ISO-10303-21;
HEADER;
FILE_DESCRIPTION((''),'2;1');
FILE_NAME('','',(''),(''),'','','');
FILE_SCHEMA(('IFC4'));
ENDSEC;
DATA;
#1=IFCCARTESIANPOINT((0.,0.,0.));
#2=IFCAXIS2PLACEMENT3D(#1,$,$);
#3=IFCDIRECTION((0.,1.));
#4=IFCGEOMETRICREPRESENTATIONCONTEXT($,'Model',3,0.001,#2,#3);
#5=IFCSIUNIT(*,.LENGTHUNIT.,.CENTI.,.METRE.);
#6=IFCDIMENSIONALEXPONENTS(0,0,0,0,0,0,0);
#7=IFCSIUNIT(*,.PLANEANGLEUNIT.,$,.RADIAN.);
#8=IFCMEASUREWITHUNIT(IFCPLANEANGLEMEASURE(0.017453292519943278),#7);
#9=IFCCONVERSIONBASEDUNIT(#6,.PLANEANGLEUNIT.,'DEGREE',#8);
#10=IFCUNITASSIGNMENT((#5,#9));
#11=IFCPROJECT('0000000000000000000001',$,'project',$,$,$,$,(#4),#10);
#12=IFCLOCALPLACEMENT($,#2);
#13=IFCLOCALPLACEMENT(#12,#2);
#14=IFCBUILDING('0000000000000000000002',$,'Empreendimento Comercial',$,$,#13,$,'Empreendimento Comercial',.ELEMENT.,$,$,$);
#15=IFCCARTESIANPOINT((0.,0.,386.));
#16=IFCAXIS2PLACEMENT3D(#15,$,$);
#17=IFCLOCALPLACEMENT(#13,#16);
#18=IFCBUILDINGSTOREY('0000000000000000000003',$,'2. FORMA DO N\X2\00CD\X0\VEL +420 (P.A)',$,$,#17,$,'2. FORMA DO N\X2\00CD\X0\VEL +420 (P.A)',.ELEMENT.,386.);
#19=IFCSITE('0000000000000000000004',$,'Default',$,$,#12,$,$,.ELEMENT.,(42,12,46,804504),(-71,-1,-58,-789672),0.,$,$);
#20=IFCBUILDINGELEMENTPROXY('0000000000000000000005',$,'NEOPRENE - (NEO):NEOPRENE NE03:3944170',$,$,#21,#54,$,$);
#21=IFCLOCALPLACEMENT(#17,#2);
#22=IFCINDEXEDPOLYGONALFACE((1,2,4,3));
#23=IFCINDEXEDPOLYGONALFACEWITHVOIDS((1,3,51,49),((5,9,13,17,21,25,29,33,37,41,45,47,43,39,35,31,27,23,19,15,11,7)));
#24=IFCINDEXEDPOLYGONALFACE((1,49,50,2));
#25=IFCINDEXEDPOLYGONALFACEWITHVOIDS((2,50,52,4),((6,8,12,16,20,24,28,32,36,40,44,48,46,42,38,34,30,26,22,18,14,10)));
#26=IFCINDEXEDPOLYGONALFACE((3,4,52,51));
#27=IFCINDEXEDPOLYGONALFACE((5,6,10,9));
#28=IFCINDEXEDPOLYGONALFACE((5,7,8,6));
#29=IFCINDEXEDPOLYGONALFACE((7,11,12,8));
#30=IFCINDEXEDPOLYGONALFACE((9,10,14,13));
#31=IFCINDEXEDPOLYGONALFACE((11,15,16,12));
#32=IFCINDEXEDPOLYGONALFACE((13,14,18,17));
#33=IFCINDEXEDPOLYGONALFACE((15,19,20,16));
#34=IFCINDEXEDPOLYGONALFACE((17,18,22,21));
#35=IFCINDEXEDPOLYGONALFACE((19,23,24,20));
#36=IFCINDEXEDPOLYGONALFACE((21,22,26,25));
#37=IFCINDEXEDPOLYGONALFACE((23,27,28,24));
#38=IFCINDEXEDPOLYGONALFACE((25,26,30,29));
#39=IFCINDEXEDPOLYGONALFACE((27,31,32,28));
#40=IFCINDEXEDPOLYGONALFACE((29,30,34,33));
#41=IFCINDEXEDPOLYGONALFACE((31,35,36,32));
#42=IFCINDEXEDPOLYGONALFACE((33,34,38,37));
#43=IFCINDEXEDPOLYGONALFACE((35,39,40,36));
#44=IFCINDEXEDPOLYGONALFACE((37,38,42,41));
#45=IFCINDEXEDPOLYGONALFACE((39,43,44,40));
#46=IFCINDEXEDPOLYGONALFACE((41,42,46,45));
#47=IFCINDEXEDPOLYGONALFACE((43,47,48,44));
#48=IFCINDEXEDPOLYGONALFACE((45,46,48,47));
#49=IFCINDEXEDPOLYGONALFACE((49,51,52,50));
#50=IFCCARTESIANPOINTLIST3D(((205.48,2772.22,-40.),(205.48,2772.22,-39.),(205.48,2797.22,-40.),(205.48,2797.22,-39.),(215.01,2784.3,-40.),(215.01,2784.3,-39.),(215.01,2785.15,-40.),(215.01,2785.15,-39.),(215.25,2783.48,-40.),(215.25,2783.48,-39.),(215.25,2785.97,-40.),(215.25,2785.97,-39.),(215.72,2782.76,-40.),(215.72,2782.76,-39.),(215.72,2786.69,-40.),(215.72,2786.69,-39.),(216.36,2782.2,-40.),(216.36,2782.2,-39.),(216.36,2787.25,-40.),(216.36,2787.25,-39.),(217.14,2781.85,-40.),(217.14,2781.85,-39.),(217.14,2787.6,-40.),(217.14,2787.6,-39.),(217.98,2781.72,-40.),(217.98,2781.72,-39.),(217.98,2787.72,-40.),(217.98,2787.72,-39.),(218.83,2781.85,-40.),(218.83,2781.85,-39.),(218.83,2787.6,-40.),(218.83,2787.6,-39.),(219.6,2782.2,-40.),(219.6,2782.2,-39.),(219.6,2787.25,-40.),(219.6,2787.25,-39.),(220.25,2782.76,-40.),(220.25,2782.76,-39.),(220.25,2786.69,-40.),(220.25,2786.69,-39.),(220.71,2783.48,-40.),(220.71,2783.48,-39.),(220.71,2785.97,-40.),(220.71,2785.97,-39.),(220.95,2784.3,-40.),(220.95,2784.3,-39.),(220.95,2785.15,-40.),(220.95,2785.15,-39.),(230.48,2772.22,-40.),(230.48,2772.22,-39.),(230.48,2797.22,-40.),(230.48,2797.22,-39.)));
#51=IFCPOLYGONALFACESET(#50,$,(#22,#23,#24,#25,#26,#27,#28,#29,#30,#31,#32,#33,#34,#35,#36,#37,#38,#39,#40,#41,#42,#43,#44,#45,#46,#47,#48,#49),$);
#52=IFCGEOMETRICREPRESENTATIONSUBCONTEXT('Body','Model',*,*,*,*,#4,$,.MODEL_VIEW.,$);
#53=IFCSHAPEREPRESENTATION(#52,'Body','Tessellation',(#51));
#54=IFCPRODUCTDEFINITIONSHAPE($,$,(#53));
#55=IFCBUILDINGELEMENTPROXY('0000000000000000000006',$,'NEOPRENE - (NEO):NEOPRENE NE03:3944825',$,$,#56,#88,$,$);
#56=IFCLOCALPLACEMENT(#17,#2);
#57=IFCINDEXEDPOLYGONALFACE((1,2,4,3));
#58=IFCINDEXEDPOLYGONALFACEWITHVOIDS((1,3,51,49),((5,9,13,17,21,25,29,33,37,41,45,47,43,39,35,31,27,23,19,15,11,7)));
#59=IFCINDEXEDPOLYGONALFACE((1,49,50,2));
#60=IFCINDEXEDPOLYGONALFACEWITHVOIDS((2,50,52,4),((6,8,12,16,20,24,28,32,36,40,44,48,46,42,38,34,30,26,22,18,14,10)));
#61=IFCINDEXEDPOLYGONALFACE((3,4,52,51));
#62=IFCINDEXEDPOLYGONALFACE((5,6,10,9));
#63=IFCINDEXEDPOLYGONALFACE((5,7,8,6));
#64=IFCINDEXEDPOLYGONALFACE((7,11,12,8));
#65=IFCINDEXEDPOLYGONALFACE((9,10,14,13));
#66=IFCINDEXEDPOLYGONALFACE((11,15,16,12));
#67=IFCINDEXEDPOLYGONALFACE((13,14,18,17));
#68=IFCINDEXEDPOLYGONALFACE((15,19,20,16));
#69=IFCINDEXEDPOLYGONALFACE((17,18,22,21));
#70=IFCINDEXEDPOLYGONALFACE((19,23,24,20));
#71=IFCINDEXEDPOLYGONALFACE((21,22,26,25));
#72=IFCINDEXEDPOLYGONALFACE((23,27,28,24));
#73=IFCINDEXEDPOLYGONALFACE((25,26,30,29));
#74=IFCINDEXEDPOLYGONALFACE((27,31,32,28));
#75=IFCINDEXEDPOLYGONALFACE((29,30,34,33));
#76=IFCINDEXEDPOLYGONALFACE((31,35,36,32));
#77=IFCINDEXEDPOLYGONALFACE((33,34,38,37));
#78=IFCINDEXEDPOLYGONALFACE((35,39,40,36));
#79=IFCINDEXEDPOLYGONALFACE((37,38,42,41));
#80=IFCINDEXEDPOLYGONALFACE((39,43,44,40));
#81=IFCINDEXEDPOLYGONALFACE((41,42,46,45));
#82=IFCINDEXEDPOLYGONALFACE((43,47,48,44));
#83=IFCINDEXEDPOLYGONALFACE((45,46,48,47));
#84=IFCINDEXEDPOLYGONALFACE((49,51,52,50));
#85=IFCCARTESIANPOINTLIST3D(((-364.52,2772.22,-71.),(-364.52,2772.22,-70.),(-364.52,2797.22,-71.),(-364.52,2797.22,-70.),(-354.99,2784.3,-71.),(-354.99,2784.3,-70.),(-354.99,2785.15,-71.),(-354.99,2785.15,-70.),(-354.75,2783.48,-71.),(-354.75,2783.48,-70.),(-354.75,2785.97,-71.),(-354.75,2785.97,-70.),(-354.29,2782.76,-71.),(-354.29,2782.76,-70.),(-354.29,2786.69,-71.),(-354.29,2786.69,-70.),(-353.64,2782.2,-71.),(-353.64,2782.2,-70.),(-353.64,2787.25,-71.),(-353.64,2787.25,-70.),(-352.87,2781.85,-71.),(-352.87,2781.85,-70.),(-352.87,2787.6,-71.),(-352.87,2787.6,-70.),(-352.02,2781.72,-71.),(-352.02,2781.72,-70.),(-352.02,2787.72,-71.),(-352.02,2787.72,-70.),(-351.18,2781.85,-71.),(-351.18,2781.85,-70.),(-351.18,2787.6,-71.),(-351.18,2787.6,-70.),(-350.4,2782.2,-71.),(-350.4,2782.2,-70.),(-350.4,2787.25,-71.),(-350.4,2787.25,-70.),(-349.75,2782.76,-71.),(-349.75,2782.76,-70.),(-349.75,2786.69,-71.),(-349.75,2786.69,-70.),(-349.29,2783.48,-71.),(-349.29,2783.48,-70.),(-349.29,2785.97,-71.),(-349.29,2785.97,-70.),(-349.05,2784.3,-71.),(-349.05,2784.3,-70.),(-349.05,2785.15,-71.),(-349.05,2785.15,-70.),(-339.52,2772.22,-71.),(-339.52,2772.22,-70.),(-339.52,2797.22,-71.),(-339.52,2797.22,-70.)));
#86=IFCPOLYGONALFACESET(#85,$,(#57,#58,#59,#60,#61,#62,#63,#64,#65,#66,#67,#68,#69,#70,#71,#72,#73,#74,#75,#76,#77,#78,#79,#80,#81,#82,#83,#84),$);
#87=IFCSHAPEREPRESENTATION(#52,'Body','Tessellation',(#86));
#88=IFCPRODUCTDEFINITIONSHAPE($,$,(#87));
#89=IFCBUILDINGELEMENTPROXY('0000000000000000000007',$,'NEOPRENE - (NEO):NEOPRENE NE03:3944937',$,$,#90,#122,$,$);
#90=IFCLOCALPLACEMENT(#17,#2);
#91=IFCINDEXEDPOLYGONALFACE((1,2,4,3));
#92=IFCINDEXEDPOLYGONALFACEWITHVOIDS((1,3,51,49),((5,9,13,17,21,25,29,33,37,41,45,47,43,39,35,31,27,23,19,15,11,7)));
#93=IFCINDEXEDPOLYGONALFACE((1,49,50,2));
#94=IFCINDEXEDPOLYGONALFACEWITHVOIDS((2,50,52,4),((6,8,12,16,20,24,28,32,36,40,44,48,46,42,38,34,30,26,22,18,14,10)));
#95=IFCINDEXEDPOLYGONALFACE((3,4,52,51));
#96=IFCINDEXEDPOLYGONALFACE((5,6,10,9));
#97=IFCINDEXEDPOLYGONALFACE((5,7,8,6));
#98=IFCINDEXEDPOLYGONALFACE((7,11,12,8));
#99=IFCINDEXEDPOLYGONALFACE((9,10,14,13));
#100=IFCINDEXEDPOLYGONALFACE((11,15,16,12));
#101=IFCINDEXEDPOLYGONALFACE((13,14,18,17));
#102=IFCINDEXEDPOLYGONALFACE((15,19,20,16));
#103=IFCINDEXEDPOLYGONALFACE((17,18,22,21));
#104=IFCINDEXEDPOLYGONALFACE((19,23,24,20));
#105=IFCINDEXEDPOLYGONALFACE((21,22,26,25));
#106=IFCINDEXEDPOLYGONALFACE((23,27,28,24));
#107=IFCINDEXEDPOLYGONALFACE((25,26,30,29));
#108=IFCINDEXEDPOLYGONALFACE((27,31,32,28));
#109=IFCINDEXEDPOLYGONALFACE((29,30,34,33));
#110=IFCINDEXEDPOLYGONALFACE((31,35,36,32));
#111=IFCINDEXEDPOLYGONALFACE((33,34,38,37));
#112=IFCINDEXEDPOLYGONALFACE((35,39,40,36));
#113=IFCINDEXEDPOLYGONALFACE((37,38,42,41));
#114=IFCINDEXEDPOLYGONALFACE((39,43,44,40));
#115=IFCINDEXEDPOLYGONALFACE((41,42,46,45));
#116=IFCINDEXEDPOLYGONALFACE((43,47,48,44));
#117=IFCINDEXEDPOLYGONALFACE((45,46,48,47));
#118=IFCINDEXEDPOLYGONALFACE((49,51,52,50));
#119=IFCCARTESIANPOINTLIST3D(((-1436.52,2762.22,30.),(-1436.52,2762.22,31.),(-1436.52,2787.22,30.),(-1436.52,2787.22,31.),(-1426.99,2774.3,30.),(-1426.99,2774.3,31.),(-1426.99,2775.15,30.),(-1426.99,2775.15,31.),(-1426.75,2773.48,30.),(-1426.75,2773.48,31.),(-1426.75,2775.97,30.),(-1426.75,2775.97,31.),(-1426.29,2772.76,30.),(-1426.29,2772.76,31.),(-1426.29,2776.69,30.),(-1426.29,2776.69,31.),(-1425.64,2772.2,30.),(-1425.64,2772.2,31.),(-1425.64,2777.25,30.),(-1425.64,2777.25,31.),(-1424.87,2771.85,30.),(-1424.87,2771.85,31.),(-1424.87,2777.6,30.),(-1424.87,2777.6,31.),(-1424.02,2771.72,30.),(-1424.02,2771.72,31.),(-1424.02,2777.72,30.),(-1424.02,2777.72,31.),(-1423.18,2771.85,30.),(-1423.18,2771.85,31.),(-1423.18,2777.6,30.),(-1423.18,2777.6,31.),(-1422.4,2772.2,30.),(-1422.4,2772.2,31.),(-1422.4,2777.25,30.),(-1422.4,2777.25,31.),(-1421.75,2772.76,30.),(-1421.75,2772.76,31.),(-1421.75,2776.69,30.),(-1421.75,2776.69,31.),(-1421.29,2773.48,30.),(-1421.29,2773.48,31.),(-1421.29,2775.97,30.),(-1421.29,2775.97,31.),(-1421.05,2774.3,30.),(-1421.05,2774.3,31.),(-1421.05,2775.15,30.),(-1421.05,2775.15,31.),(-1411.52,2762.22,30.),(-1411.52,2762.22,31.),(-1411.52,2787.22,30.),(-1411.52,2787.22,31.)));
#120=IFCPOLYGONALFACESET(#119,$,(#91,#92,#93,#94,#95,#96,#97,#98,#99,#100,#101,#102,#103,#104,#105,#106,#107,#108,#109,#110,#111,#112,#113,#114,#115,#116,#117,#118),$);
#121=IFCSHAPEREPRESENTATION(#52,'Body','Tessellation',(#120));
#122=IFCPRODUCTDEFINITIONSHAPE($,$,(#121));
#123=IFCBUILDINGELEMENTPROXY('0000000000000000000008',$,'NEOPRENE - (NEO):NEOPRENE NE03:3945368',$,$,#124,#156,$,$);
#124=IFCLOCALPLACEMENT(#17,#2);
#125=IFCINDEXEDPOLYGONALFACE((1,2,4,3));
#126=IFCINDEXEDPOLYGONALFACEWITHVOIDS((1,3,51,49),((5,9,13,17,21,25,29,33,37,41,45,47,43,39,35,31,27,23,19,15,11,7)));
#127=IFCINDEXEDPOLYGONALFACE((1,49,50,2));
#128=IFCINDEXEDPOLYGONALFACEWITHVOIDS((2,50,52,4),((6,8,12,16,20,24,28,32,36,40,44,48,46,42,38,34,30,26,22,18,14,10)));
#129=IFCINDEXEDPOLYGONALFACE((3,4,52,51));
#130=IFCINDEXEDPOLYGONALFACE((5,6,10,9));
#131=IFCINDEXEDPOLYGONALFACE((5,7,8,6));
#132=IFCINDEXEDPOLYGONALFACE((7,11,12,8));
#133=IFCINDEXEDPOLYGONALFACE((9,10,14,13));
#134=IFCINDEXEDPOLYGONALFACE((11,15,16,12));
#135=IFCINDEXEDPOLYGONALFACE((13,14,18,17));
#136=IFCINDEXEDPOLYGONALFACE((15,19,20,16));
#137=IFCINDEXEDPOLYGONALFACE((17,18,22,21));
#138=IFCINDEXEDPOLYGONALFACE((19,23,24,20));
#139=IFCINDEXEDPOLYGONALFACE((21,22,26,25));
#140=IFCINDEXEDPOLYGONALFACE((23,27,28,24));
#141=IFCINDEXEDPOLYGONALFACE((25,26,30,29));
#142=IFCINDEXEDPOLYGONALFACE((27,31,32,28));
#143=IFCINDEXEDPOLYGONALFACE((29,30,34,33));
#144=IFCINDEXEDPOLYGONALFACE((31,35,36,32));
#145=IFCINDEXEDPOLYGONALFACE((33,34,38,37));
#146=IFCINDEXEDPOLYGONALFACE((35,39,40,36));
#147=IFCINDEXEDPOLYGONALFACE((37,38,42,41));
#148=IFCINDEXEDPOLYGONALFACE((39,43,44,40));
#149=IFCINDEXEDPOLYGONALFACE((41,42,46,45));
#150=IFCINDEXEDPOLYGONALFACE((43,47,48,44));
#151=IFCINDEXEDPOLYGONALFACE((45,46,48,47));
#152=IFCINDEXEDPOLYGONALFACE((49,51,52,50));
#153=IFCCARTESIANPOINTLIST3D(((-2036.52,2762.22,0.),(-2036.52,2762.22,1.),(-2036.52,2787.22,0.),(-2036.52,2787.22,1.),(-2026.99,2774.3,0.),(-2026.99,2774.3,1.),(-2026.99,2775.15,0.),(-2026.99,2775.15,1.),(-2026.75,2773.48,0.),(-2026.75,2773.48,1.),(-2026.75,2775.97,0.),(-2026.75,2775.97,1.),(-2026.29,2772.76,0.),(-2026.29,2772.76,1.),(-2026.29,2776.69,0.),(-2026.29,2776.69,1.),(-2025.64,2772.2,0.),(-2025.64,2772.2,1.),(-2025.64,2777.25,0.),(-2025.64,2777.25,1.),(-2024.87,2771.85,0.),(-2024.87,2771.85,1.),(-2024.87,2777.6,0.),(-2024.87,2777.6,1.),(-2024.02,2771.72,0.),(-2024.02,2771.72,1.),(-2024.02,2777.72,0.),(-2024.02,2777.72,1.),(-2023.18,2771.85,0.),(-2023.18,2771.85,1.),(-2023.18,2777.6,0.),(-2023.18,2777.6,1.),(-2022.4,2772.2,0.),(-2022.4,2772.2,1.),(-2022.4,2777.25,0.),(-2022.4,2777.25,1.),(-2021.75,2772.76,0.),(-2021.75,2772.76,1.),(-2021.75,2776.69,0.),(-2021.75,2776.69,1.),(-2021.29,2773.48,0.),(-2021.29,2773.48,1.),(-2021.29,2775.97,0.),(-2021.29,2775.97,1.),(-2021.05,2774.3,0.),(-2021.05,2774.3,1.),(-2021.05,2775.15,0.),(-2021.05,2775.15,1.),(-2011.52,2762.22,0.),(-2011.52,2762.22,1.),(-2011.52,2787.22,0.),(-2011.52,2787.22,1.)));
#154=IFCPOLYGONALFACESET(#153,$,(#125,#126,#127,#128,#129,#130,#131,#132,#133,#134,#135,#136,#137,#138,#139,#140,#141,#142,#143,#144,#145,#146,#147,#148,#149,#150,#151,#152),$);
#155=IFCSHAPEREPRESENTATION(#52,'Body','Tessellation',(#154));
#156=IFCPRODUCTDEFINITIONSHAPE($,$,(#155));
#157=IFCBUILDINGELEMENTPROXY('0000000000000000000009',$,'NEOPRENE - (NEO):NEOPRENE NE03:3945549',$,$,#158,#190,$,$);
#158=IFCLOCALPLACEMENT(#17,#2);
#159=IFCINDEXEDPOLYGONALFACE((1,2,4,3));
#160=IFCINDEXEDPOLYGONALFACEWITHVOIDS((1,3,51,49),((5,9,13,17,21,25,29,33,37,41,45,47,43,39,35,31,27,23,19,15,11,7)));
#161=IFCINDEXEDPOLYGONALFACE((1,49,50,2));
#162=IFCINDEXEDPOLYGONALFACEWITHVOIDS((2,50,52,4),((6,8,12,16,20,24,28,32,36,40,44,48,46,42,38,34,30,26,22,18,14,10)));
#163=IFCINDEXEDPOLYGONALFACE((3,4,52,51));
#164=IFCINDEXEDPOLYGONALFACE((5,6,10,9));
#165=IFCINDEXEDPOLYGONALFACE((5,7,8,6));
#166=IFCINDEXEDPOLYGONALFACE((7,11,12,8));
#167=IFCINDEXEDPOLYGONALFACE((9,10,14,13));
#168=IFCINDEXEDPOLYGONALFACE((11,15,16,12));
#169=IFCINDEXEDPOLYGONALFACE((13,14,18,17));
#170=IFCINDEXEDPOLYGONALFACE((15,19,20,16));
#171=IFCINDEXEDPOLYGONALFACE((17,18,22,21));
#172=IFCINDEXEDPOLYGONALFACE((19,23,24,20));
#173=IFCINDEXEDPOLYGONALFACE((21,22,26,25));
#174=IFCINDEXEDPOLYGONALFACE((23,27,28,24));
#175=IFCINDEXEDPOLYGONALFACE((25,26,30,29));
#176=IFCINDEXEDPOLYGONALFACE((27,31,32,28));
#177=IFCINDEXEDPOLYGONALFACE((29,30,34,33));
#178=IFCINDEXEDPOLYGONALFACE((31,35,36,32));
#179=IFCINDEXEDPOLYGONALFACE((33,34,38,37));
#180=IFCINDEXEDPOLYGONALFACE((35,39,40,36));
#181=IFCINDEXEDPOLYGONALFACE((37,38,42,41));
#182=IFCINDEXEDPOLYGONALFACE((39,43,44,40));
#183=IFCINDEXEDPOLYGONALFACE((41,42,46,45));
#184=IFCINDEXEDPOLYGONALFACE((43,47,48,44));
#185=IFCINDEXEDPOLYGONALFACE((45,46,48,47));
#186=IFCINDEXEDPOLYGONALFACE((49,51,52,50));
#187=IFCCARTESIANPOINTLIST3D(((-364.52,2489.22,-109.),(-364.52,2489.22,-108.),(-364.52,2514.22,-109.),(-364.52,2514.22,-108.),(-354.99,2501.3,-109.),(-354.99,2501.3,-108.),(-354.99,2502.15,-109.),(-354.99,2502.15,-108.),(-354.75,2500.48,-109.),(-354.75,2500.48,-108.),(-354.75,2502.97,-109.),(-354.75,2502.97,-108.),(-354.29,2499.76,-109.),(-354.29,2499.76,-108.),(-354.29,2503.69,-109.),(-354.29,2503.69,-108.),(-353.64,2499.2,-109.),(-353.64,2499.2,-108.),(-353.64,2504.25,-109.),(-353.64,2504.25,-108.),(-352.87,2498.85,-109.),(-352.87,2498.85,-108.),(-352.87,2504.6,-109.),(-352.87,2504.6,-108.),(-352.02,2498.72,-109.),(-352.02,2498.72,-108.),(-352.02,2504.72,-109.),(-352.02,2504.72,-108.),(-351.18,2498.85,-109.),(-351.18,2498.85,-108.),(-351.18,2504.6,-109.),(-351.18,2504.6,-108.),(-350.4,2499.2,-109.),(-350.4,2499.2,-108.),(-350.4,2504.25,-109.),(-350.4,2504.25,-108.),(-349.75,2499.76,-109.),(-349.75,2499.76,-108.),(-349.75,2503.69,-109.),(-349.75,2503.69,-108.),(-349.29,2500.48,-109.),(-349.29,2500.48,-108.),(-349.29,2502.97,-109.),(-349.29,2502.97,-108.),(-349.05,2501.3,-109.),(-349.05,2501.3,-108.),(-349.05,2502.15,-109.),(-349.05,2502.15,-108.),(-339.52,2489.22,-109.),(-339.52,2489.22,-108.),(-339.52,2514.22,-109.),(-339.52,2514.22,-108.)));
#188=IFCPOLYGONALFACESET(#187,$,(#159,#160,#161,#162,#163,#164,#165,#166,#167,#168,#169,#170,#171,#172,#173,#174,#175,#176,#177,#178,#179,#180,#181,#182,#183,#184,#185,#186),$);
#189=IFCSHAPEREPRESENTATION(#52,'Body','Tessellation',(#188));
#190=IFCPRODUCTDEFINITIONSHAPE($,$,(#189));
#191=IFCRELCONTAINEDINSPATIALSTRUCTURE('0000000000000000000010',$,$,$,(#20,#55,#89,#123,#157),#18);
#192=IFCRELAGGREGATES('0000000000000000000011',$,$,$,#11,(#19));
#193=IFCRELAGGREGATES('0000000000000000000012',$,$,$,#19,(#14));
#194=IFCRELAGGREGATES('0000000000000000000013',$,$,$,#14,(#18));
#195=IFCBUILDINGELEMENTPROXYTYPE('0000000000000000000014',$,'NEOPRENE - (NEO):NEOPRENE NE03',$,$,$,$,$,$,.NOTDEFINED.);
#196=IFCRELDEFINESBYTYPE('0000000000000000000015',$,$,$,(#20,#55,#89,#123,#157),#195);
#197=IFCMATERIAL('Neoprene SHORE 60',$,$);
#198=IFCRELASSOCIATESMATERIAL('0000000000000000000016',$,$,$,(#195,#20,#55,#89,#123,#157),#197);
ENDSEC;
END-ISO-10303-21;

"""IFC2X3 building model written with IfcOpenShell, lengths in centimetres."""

from ifc_helpers import new_model, entity, si_unit, converted_unit, direction, frame, frame_2d, origin, place, context, subcontext, project, spatial, polyline, circle_curve, parameter, trimmed, segment, composite_curve, outline, extrude, source, transform, mapped, material, type_object, type_shapes, element, save


model = new_model("IFC2X3")

# Units and contexts
model_context = context("Model", 3, precision=0.001, world=origin(), true_north=direction((0.0, 1.0)))
body_context = subcontext(model_context, "Body", "Model", "MODEL_VIEW")
ifc_project = project(units=[si_unit("LENGTHUNIT", "METRE", prefix="CENTI"), converted_unit("PLANEANGLEUNIT", "DEGREE", entity("IfcPlaneAngleMeasure", 0.017453292519943278), si_unit("PLANEANGLEUNIT", "RADIAN"), dimensions=[0, 0, 0, 0, 0, 0, 0])], contexts=[model_context])

# Site, building, storey
site_placement = place(None, origin())
site = spatial("IfcSite", under=ifc_project, at=site_placement, Name="Default", CompositionType="ELEMENT", RefLatitude=(42, 12, 46, 804504), RefLongitude=(-71, -1, -58, -789672), RefElevation=0.0)
building_placement = place(site_placement, origin())
building = spatial("IfcBuilding", under=site, at=building_placement, Name="Empreendimento Comercial", LongName="Empreendimento Comercial", CompositionType="ELEMENT")
storey_placement = place(building_placement, frame((0.0, 0.0, 386.0)))
storey = spatial("IfcBuildingStorey", under=building, at=storey_placement, Name="2. FORMA DO NÍVEL +420 (P.A)", LongName="2. FORMA DO NÍVEL +420 (P.A)", CompositionType="ELEMENT", Elevation=386.0)

# Building element proxies
ifc_material = material(Name="Neoprene SHORE 60")
building_element_proxy_type_1 = type_object("IfcBuildingElementProxyType", Name="NEOPRENE - (NEO):NEOPRENE NE03", PredefinedType="NOTDEFINED", material=ifc_material)
shared_shape_1 = source(origin(), body_context, "Body", "SweptSolid", [
    extrude(outline(polyline([(-12.5, -12.5), (12.5, -12.5), (12.5, 12.5), (-12.5, 12.5), (-12.5, -12.5)]), holes=[composite_curve([segment(trimmed(circle_curve(frame_2d((0.0, 0.0), x_axis=(-1.0, 0.0)), 3.0), [parameter(0.0)], [parameter(180.0)], True, "PARAMETER"), False, "CONTINUOUS"), segment(trimmed(circle_curve(frame_2d((0.0, 0.0), x_axis=(-1.0, 0.0)), 3.0), [parameter(180.0)], [parameter(0.0)], True, "PARAMETER"), False, "CONTINUOUS")], self_intersect=False)]), frame((0.0, 0.0, -71.0), z_axis=(0.0, 0.0, 1.0), x_axis=(-1.0, 0.0, 0.0)), (0.0, 0.0, 1.0), 1.0),
])
type_shapes(building_element_proxy_type_1, [shared_shape_1])
for number, where, z_axis, x_axis, name in (
    (1, (217.98, 2784.72, 31.0), (0.0, 0.0, 1.0), (0.0, -1.0, 0.0), "NEOPRENE - (NEO):NEOPRENE NE03:3944170"),
    (2, (-352.02, 2784.72, 0.0), (0.0, 0.0, 1.0), (0.0, -1.0, 0.0), "NEOPRENE - (NEO):NEOPRENE NE03:3944825"),
    (3, (-1424.02, 2774.72, 101.0), (0.0, 0.0, 1.0), (0.0, -1.0, 0.0), "NEOPRENE - (NEO):NEOPRENE NE03:3944937"),
    (4, (-2024.02, 2774.72, 71.0), (0.0, 0.0, 1.0), (0.0, -1.0, 0.0), "NEOPRENE - (NEO):NEOPRENE NE03:3945368"),
    (5, (-352.02, 2501.72, -38.0), (0.0, 0.0, 1.0), (0.0, -1.0, 0.0), "NEOPRENE - (NEO):NEOPRENE NE03:3945549"),
):
    element("IfcBuildingElementProxy", number, at=place(storey_placement, frame(where, z_axis=z_axis, x_axis=x_axis)), inside=storey, type_object=building_element_proxy_type_1, material=ifc_material, Name=name, context=body_context, shape_type="MappedRepresentation", body=[
        mapped(shared_shape_1, transform((0.0, 0.0, 0.0), scale=1.0)),
    ])

save(model, "model.ifc")
